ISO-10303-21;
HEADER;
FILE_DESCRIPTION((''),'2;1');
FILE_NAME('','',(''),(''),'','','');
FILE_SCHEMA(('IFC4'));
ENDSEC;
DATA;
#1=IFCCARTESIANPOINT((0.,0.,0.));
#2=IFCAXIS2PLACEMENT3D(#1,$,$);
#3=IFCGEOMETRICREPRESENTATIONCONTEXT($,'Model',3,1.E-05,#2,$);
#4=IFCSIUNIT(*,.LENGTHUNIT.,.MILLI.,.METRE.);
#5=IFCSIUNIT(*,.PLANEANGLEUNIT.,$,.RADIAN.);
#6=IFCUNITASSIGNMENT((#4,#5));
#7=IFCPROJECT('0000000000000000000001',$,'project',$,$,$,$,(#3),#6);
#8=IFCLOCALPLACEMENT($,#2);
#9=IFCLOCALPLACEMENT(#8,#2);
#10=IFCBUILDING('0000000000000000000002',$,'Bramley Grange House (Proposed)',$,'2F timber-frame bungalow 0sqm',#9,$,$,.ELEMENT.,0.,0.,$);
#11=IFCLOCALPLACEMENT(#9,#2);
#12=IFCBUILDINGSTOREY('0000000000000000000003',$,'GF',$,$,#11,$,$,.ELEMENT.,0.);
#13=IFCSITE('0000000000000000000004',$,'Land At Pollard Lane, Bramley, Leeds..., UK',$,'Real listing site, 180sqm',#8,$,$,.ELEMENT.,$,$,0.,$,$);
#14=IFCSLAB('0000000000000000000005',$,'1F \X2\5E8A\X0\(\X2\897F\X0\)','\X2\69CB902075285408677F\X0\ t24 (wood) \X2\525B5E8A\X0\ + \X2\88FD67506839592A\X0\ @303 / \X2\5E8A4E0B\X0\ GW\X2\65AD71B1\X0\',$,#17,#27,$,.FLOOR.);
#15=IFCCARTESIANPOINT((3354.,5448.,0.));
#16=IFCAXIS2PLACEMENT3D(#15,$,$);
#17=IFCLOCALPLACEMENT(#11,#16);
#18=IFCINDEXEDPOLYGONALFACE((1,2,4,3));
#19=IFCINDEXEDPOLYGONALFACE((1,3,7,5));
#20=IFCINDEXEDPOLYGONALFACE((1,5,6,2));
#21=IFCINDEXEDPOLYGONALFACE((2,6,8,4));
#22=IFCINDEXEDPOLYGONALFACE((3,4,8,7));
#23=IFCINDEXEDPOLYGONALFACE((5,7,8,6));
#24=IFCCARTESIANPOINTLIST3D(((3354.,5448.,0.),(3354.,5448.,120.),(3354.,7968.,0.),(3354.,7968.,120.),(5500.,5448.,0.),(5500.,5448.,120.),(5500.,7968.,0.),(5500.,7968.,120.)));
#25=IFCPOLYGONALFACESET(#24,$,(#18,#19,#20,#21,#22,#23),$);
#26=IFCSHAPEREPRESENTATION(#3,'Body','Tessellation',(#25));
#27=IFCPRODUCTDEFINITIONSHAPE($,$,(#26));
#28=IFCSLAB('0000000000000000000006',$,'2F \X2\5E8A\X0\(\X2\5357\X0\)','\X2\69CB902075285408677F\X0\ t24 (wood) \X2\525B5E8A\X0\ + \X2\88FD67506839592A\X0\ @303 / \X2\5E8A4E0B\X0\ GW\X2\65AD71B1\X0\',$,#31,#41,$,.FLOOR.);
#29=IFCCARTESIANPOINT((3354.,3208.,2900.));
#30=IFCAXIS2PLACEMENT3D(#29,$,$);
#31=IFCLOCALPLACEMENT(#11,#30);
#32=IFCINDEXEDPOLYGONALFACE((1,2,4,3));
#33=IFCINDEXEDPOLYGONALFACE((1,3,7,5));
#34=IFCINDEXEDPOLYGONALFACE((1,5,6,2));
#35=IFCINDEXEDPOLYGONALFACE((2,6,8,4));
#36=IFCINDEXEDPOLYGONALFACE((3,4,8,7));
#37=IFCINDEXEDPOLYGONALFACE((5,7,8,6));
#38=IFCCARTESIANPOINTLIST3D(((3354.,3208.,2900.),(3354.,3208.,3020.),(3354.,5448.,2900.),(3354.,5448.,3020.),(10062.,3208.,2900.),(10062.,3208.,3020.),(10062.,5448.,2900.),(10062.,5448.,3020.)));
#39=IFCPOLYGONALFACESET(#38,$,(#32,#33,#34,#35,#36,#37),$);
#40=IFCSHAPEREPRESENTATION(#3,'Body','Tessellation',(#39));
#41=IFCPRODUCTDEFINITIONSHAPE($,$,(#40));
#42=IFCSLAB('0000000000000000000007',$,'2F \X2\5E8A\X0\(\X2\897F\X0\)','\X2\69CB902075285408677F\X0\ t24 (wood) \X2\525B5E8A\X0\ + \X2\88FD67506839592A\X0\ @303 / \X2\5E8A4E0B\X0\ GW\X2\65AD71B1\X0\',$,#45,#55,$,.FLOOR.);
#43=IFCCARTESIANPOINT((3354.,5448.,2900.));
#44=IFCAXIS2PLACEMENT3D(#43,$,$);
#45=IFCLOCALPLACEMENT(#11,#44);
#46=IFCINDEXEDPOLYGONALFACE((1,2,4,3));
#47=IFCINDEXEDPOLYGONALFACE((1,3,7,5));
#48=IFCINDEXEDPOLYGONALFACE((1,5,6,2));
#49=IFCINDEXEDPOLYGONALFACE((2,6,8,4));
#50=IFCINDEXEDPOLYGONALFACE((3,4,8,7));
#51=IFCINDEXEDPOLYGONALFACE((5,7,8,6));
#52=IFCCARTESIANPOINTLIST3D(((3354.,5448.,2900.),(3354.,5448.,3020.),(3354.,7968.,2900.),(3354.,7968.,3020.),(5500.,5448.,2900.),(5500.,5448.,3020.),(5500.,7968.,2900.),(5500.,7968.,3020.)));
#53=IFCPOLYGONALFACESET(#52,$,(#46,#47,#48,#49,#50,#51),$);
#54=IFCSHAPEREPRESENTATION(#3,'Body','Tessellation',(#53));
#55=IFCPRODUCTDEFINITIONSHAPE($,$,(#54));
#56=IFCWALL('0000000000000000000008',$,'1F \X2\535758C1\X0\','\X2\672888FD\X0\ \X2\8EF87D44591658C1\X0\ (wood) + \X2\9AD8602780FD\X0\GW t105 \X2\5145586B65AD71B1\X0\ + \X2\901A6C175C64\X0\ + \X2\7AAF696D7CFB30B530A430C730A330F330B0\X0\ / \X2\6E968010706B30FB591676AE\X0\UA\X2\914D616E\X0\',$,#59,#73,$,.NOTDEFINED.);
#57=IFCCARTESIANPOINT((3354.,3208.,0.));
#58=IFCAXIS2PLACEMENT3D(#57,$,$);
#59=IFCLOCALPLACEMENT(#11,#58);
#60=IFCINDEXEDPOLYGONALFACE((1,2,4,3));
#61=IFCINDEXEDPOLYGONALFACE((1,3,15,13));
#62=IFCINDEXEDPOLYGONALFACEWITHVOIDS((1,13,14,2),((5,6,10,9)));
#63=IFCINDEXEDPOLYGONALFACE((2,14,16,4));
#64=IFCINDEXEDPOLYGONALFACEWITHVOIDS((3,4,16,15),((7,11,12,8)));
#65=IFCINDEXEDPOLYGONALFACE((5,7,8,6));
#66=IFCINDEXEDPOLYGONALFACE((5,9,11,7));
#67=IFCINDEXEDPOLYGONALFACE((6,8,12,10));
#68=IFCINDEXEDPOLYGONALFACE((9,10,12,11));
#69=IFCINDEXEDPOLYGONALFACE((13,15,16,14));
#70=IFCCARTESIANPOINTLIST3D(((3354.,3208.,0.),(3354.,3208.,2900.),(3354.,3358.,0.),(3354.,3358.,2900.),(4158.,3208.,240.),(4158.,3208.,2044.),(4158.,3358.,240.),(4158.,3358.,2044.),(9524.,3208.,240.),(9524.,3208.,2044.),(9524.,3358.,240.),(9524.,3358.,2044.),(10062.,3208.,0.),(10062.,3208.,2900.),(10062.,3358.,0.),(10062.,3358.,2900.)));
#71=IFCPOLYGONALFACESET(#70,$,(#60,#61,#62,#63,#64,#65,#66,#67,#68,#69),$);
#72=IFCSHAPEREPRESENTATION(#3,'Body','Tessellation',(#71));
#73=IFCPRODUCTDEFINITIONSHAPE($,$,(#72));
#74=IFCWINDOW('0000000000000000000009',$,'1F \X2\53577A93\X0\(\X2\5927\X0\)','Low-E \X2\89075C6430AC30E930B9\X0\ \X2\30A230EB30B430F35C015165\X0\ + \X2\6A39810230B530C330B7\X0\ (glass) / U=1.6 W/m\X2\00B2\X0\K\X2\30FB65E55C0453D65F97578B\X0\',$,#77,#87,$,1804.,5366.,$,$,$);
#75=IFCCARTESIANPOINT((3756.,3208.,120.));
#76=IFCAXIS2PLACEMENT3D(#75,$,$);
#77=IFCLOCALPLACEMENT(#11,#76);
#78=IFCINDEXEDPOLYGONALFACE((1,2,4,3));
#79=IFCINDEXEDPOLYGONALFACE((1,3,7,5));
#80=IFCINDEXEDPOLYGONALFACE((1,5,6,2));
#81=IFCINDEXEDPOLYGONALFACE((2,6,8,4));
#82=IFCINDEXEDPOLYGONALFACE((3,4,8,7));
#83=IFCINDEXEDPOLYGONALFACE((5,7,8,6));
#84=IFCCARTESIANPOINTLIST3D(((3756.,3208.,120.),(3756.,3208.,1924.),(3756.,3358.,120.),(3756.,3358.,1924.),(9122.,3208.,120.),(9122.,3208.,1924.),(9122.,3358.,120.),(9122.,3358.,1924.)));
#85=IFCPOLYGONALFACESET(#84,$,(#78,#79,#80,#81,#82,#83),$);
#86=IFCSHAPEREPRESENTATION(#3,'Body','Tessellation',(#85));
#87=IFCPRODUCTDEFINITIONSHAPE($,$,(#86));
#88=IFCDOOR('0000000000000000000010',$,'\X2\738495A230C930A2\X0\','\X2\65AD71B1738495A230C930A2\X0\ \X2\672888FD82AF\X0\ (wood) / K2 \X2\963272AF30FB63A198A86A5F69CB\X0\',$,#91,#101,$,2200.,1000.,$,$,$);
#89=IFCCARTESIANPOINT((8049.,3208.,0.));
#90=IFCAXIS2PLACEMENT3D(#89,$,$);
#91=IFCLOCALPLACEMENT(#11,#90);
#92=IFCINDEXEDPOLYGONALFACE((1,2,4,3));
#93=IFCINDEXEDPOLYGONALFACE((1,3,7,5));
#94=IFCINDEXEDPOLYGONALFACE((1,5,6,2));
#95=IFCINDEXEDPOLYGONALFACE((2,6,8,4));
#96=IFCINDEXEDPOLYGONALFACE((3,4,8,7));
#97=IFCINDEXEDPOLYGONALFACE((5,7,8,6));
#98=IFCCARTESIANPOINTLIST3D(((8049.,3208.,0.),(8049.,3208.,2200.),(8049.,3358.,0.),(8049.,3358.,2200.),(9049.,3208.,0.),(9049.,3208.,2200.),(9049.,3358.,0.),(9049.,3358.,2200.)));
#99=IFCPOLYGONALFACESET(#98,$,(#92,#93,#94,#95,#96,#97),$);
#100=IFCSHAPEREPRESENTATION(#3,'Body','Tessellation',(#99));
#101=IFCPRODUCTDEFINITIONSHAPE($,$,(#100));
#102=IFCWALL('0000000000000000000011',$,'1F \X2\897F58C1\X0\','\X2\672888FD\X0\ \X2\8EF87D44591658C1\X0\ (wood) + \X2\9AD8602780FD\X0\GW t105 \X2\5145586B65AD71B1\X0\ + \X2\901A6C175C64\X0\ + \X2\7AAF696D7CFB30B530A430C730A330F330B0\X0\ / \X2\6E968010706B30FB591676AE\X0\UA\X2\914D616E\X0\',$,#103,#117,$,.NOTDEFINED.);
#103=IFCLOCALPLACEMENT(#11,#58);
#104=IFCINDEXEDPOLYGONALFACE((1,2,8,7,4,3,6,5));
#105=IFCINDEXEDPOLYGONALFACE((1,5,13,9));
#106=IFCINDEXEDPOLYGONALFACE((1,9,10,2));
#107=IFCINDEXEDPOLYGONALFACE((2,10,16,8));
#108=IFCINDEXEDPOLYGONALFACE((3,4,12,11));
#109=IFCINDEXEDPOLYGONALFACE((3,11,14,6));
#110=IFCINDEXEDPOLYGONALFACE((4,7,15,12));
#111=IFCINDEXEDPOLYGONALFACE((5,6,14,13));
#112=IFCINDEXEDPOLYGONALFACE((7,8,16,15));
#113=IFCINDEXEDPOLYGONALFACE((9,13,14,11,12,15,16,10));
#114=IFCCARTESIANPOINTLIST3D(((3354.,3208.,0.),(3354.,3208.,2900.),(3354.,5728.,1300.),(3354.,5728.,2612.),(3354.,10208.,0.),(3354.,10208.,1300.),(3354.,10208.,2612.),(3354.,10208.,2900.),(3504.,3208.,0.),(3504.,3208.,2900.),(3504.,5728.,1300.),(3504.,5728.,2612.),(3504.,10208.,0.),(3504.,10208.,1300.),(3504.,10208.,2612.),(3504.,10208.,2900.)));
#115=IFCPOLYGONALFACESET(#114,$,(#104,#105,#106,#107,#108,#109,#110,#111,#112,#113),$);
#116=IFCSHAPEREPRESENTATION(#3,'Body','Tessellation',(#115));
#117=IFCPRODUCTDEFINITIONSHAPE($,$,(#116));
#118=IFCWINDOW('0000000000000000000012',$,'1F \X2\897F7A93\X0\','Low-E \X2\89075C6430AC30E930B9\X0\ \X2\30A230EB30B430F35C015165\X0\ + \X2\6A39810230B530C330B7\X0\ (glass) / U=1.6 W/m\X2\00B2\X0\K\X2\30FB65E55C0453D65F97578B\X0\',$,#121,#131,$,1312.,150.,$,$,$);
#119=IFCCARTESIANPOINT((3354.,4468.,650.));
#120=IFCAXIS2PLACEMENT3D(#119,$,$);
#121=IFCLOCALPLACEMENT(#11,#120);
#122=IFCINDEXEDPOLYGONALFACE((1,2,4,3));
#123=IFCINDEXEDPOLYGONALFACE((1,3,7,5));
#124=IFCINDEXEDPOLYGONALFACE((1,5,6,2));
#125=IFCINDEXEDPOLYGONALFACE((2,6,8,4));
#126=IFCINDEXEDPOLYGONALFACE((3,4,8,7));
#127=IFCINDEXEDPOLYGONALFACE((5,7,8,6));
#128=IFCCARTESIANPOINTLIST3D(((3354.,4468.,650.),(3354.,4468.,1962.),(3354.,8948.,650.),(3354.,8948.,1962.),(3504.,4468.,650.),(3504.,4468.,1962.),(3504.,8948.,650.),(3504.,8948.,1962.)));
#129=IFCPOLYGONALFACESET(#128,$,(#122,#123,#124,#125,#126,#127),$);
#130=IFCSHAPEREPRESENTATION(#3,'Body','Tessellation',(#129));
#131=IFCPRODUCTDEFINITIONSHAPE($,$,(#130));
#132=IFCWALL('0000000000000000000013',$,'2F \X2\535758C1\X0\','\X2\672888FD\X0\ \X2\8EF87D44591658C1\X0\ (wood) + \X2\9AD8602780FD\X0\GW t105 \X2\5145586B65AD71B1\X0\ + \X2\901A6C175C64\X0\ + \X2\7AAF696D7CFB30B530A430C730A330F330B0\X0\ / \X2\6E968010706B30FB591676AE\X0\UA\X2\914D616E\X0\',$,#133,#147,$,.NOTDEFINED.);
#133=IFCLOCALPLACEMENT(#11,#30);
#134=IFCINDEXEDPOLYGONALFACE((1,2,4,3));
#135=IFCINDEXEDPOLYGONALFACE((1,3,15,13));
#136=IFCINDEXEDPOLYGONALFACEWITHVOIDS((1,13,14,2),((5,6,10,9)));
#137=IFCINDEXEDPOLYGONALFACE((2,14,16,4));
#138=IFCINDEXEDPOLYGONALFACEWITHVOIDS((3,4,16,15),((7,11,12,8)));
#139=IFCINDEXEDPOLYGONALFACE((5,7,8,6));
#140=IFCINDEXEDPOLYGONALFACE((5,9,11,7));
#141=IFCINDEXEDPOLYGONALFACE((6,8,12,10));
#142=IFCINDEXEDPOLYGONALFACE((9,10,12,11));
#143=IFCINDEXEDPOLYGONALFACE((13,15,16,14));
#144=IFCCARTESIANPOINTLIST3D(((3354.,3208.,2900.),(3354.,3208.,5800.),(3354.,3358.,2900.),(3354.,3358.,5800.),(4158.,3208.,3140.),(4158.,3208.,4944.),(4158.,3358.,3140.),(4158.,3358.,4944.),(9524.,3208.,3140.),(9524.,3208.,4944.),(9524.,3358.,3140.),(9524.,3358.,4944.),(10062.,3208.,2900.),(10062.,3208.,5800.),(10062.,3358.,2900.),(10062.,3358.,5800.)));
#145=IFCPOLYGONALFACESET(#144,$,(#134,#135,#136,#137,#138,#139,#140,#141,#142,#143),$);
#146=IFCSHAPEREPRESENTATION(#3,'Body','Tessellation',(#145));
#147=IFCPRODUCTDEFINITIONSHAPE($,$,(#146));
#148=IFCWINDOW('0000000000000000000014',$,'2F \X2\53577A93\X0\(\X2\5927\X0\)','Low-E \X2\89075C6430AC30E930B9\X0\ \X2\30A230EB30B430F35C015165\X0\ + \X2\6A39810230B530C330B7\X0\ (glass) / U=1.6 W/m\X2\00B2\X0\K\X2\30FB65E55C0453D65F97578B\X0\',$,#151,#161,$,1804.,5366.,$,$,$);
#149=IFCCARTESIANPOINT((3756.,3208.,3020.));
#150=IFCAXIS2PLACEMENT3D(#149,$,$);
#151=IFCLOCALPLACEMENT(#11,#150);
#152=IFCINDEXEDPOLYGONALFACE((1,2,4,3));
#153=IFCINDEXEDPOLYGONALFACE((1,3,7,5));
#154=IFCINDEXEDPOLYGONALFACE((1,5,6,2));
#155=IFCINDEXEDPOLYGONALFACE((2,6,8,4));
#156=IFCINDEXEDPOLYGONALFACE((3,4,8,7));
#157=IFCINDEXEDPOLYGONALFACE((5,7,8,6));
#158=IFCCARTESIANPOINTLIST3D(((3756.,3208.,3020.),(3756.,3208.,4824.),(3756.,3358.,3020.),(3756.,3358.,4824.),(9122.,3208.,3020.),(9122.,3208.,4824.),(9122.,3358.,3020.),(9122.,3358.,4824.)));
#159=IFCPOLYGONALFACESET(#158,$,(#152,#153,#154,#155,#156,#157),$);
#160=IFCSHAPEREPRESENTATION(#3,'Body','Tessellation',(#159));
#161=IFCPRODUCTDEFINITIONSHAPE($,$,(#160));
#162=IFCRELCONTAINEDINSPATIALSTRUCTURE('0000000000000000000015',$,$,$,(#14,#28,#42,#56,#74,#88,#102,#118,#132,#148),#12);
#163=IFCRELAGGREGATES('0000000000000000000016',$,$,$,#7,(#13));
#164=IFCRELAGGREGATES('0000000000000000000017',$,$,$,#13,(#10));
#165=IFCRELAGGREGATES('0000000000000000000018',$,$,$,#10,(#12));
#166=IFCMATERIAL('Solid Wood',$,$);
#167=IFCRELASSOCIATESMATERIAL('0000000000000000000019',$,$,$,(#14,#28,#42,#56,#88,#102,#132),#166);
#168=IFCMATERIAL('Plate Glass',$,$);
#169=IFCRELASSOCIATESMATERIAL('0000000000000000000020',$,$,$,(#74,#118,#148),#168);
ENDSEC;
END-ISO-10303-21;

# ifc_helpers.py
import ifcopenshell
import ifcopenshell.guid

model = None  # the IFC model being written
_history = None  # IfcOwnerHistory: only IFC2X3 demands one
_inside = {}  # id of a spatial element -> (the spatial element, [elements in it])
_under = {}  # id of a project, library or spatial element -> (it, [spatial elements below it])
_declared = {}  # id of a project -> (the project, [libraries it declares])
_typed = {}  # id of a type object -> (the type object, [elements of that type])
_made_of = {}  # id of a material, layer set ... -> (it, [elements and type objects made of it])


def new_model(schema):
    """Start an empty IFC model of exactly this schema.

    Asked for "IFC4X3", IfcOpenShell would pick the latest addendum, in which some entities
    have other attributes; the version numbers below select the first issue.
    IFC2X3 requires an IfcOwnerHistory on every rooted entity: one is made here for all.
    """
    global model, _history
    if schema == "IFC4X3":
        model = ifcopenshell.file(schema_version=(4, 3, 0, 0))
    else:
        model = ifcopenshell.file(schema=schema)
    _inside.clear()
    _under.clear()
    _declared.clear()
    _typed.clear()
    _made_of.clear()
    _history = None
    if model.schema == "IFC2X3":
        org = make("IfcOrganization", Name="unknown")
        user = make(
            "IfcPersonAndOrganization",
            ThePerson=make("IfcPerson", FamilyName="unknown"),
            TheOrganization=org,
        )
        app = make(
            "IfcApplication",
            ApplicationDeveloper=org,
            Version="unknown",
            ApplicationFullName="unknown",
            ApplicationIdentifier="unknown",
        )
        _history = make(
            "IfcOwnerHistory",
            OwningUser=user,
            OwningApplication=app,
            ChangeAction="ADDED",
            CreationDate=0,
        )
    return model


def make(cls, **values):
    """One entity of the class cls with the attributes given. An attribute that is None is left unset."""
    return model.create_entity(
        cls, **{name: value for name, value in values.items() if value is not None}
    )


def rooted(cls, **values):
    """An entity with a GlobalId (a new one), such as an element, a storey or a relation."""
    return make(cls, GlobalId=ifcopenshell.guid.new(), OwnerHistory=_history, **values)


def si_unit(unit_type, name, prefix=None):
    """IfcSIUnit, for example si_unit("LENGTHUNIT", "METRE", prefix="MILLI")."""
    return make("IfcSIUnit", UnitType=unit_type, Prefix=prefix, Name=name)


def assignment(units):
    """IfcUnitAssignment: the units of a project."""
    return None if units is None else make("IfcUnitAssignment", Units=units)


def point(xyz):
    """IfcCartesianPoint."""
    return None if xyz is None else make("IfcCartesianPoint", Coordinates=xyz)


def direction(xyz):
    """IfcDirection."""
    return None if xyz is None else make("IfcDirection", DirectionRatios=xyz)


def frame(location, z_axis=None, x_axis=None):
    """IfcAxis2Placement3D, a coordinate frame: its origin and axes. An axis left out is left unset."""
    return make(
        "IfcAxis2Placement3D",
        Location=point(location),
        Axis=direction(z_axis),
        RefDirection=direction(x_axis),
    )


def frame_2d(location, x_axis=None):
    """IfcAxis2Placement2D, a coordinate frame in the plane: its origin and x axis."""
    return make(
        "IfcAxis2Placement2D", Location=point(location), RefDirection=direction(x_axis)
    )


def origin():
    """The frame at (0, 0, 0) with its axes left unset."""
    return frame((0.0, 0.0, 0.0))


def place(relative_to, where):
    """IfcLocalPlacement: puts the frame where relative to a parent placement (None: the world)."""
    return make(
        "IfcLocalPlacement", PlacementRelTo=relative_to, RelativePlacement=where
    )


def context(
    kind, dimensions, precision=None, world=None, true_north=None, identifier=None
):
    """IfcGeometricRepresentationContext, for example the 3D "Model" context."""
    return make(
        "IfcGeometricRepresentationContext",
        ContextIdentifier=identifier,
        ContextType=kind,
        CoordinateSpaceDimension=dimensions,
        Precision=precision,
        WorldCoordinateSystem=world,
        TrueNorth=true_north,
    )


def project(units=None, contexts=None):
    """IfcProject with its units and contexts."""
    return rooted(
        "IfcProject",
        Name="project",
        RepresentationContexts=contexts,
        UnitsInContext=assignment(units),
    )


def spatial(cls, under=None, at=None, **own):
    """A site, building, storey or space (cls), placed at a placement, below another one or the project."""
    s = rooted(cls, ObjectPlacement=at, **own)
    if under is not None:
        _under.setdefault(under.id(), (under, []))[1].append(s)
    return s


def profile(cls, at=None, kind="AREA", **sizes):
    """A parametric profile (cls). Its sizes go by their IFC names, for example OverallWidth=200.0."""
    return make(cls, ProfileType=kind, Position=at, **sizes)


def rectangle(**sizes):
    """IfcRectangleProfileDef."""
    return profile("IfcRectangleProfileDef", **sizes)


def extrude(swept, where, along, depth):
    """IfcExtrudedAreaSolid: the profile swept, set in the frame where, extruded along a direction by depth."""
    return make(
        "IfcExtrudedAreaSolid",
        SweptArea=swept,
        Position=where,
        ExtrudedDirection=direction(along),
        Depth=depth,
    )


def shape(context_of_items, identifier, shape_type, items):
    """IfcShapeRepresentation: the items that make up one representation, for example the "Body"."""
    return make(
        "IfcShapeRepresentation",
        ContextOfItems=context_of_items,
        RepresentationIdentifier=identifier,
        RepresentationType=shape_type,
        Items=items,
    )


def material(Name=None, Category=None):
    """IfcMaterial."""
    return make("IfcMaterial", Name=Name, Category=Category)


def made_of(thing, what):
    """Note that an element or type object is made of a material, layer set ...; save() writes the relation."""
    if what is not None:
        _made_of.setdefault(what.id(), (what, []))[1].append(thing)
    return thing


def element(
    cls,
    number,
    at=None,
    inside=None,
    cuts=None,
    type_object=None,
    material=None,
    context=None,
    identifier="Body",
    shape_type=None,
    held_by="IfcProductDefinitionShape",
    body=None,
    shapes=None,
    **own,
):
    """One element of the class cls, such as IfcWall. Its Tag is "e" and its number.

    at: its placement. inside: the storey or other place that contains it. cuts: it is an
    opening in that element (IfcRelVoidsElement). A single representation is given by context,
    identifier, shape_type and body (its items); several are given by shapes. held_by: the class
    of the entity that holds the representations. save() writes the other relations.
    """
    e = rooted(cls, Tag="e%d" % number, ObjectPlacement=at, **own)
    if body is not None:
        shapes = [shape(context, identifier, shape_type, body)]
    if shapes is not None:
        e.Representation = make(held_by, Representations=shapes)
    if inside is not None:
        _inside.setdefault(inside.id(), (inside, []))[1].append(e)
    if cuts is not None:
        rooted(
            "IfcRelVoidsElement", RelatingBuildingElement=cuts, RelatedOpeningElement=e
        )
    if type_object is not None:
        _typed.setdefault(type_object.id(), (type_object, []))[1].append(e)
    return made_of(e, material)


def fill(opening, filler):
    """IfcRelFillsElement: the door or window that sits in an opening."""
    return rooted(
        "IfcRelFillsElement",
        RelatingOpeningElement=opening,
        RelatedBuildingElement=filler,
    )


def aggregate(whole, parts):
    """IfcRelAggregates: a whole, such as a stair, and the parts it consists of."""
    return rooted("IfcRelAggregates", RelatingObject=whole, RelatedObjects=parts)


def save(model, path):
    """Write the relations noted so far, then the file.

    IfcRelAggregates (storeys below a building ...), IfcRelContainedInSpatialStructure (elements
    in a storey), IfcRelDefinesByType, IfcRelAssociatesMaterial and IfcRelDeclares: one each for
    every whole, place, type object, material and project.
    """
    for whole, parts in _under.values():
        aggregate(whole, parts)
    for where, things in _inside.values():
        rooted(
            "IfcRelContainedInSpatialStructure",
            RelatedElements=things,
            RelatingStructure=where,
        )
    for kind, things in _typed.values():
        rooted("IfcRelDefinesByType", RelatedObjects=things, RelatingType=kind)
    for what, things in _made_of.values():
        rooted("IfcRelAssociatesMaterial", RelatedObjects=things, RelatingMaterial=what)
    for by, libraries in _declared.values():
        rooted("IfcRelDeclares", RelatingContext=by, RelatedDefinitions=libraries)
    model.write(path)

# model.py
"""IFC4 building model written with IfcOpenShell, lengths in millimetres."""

from ifc_helpers import new_model, si_unit, frame, frame_2d, origin, place, context, project, spatial, rectangle, extrude, material, element, fill, save


model = new_model("IFC4")

# Units and contexts
model_context = context("Model", 3, precision=1e-05, world=origin())
ifc_project = project(units=[si_unit("LENGTHUNIT", "METRE", prefix="MILLI"), si_unit("PLANEANGLEUNIT", "RADIAN")], contexts=[model_context])

# Site, building, storey
site_placement = place(None, origin())
site = spatial("IfcSite", under=ifc_project, at=site_placement, Name="Land At Pollard Lane, Bramley, Leeds..., UK", ObjectType="Real listing site, 180sqm", CompositionType="ELEMENT", RefElevation=0.0)
building_placement = place(site_placement, origin())
building = spatial("IfcBuilding", under=site, at=building_placement, Name="Bramley Grange House (Proposed)", ObjectType="2F timber-frame bungalow 0sqm", CompositionType="ELEMENT", ElevationOfRefHeight=0.0, ElevationOfTerrain=0.0)
storey_placement = place(building_placement, origin())
storey = spatial("IfcBuildingStorey", under=building, at=storey_placement, Name="GF", CompositionType="ELEMENT", Elevation=0.0)

# Slabs
ifc_material_1 = material(Name="Solid Wood")
slab_1_placement = place(storey_placement, frame((3354.0, 5448.0, 0.0)))
element("IfcSlab", 1, at=slab_1_placement, inside=storey, material=ifc_material_1, Name="1F 床(西)", Description="構造用合板 t24 (wood) 剛床 + 製材根太 @303 / 床下 GW断熱", PredefinedType="FLOOR", context=model_context, shape_type="SweptSolid", body=[
    extrude(rectangle(XDim=2146.0, YDim=2520.0, at=frame_2d((1073.0, 1260.0))), frame((3354.0, 5448.0, 0.0)), (0.0, 0.0, 1.0), 120.0),
])
slab_2_placement = place(storey_placement, frame((3354.0, 3208.0, 2900.0)))
element("IfcSlab", 2, at=slab_2_placement, inside=storey, material=ifc_material_1, Name="2F 床(南)", Description="構造用合板 t24 (wood) 剛床 + 製材根太 @303 / 床下 GW断熱", PredefinedType="FLOOR", context=model_context, shape_type="SweptSolid", body=[
    extrude(rectangle(XDim=6708.0, YDim=2240.0, at=frame_2d((3354.0, 1120.0))), frame((3354.0, 3208.0, 2900.0)), (0.0, 0.0, 1.0), 120.0),
])
slab_3_placement = place(storey_placement, frame((3354.0, 5448.0, 2900.0)))
element("IfcSlab", 3, at=slab_3_placement, inside=storey, material=ifc_material_1, Name="2F 床(西)", Description="構造用合板 t24 (wood) 剛床 + 製材根太 @303 / 床下 GW断熱", PredefinedType="FLOOR", context=model_context, shape_type="SweptSolid", body=[
    extrude(rectangle(XDim=2146.0, YDim=2520.0, at=frame_2d((1073.0, 1260.0))), frame((3354.0, 5448.0, 2900.0)), (0.0, 0.0, 1.0), 120.0),
])

# Wall, openings, window, door
wall_1_placement = place(storey_placement, frame((3354.0, 3208.0, 0.0)))
wall_1 = element("IfcWall", 4, at=wall_1_placement, inside=storey, material=ifc_material_1, Name="1F 南壁", Description="木製 軸組外壁 (wood) + 高性能GW t105 充填断熱 + 通気層 + 窯業系サイディング / 準耐火・外皮UA配慮", PredefinedType="NOTDEFINED", context=model_context, shape_type="SweptSolid", body=[
    extrude(rectangle(XDim=6708.0, YDim=150.0, at=frame_2d((3354.0, 75.0))), frame((3354.0, 3208.0, 0.0)), (0.0, 0.0, 1.0), 2900.0),
])
opening_1_placement = place(storey_placement, frame((3756.0, 3208.0, 120.0)))
opening_1 = element("IfcOpeningElement", 5, at=opening_1_placement, cuts=wall_1, PredefinedType="NOTDEFINED", context=model_context, shape_type="SweptSolid", body=[
    extrude(rectangle(XDim=5366.0, YDim=150.0, at=frame_2d((2683.0, 75.0))), frame((3756.0, 3208.0, 120.0)), (0.0, 0.0, 1.0), 1804.0),
])
opening_2_placement = place(storey_placement, frame((8049.0, 3208.0, 0.0)))
opening_2 = element("IfcOpeningElement", 6, at=opening_2_placement, cuts=wall_1, PredefinedType="NOTDEFINED", context=model_context, shape_type="SweptSolid", body=[
    extrude(rectangle(XDim=1000.0, YDim=150.0, at=frame_2d((500.0, 75.0))), frame((8049.0, 3208.0, 0.0)), (0.0, 0.0, 1.0), 2200.0),
])
ifc_material_2 = material(Name="Plate Glass")
window_1_placement = place(storey_placement, frame((3756.0, 3208.0, 120.0)))
window_1 = element("IfcWindow", 7, at=window_1_placement, inside=storey, material=ifc_material_2, Name="1F 南窓(大)", Description="Low-E 複層ガラス アルゴン封入 + 樹脂サッシ (glass) / U=1.6 W/m²K・日射取得型", OverallHeight=1804.0, OverallWidth=5366.0, context=model_context, shape_type="SweptSolid", body=[
    extrude(rectangle(XDim=5366.0, YDim=150.0, at=frame_2d((2683.0, 75.0))), frame((3756.0, 3208.0, 120.0)), (0.0, 0.0, 1.0), 1804.0),
])
fill(opening_1, window_1)
door_placement = place(storey_placement, frame((8049.0, 3208.0, 0.0)))
door = element("IfcDoor", 8, at=door_placement, inside=storey, material=ifc_material_1, Name="玄関ドア", Description="断熱玄関ドア 木製芯 (wood) / K2 防犯・採風機構", OverallHeight=2200.0, OverallWidth=1000.0, context=model_context, shape_type="SweptSolid", body=[
    extrude(rectangle(XDim=1000.0, YDim=150.0, at=frame_2d((500.0, 75.0))), frame((8049.0, 3208.0, 0.0)), (0.0, 0.0, 1.0), 2200.0),
])
fill(opening_2, door)

# Walls, openings, windows
wall_2_placement = place(storey_placement, frame((3354.0, 3208.0, 0.0)))
wall_2 = element("IfcWall", 9, at=wall_2_placement, inside=storey, material=ifc_material_1, Name="1F 西壁", Description="木製 軸組外壁 (wood) + 高性能GW t105 充填断熱 + 通気層 + 窯業系サイディング / 準耐火・外皮UA配慮", PredefinedType="NOTDEFINED", context=model_context, shape_type="SweptSolid", body=[
    extrude(rectangle(XDim=150.0, YDim=7000.0, at=frame_2d((75.0, 3500.0))), frame((3354.0, 3208.0, 0.0)), (0.0, 0.0, 1.0), 2900.0),
])
opening_3_placement = place(storey_placement, frame((3354.0, 4468.0, 650.0)))
opening_3 = element("IfcOpeningElement", 10, at=opening_3_placement, cuts=wall_2, PredefinedType="NOTDEFINED", context=model_context, shape_type="SweptSolid", body=[
    extrude(rectangle(XDim=150.0, YDim=4480.0, at=frame_2d((75.0, 2240.0))), frame((3354.0, 4468.0, 650.0)), (0.0, 0.0, 1.0), 1312.0),
])
window_2_placement = place(storey_placement, frame((3354.0, 4468.0, 650.0)))
window_2 = element("IfcWindow", 11, at=window_2_placement, inside=storey, material=ifc_material_2, Name="1F 西窓", Description="Low-E 複層ガラス アルゴン封入 + 樹脂サッシ (glass) / U=1.6 W/m²K・日射取得型", OverallHeight=1312.0, OverallWidth=150.0, context=model_context, shape_type="SweptSolid", body=[
    extrude(rectangle(XDim=150.0, YDim=4480.0, at=frame_2d((75.0, 2240.0))), frame((3354.0, 4468.0, 650.0)), (0.0, 0.0, 1.0), 1312.0),
])
fill(opening_3, window_2)
wall_3_placement = place(storey_placement, frame((3354.0, 3208.0, 2900.0)))
wall_3 = element("IfcWall", 12, at=wall_3_placement, inside=storey, material=ifc_material_1, Name="2F 南壁", Description="木製 軸組外壁 (wood) + 高性能GW t105 充填断熱 + 通気層 + 窯業系サイディング / 準耐火・外皮UA配慮", PredefinedType="NOTDEFINED", context=model_context, shape_type="SweptSolid", body=[
    extrude(rectangle(XDim=6708.0, YDim=150.0, at=frame_2d((3354.0, 75.0))), frame((3354.0, 3208.0, 2900.0)), (0.0, 0.0, 1.0), 2900.0),
])
opening_4_placement = place(storey_placement, frame((3756.0, 3208.0, 3020.0)))
opening_4 = element("IfcOpeningElement", 13, at=opening_4_placement, cuts=wall_3, PredefinedType="NOTDEFINED", context=model_context, shape_type="SweptSolid", body=[
    extrude(rectangle(XDim=5366.0, YDim=150.0, at=frame_2d((2683.0, 75.0))), frame((3756.0, 3208.0, 3020.0)), (0.0, 0.0, 1.0), 1804.0),
])
window_3_placement = place(storey_placement, frame((3756.0, 3208.0, 3020.0)))
window_3 = element("IfcWindow", 14, at=window_3_placement, inside=storey, material=ifc_material_2, Name="2F 南窓(大)", Description="Low-E 複層ガラス アルゴン封入 + 樹脂サッシ (glass) / U=1.6 W/m²K・日射取得型", OverallHeight=1804.0, OverallWidth=5366.0, context=model_context, shape_type="SweptSolid", body=[
    extrude(rectangle(XDim=5366.0, YDim=150.0, at=frame_2d((2683.0, 75.0))), frame((3756.0, 3208.0, 3020.0)), (0.0, 0.0, 1.0), 1804.0),
])
fill(opening_4, window_3)

save(model, "model.ifc")
